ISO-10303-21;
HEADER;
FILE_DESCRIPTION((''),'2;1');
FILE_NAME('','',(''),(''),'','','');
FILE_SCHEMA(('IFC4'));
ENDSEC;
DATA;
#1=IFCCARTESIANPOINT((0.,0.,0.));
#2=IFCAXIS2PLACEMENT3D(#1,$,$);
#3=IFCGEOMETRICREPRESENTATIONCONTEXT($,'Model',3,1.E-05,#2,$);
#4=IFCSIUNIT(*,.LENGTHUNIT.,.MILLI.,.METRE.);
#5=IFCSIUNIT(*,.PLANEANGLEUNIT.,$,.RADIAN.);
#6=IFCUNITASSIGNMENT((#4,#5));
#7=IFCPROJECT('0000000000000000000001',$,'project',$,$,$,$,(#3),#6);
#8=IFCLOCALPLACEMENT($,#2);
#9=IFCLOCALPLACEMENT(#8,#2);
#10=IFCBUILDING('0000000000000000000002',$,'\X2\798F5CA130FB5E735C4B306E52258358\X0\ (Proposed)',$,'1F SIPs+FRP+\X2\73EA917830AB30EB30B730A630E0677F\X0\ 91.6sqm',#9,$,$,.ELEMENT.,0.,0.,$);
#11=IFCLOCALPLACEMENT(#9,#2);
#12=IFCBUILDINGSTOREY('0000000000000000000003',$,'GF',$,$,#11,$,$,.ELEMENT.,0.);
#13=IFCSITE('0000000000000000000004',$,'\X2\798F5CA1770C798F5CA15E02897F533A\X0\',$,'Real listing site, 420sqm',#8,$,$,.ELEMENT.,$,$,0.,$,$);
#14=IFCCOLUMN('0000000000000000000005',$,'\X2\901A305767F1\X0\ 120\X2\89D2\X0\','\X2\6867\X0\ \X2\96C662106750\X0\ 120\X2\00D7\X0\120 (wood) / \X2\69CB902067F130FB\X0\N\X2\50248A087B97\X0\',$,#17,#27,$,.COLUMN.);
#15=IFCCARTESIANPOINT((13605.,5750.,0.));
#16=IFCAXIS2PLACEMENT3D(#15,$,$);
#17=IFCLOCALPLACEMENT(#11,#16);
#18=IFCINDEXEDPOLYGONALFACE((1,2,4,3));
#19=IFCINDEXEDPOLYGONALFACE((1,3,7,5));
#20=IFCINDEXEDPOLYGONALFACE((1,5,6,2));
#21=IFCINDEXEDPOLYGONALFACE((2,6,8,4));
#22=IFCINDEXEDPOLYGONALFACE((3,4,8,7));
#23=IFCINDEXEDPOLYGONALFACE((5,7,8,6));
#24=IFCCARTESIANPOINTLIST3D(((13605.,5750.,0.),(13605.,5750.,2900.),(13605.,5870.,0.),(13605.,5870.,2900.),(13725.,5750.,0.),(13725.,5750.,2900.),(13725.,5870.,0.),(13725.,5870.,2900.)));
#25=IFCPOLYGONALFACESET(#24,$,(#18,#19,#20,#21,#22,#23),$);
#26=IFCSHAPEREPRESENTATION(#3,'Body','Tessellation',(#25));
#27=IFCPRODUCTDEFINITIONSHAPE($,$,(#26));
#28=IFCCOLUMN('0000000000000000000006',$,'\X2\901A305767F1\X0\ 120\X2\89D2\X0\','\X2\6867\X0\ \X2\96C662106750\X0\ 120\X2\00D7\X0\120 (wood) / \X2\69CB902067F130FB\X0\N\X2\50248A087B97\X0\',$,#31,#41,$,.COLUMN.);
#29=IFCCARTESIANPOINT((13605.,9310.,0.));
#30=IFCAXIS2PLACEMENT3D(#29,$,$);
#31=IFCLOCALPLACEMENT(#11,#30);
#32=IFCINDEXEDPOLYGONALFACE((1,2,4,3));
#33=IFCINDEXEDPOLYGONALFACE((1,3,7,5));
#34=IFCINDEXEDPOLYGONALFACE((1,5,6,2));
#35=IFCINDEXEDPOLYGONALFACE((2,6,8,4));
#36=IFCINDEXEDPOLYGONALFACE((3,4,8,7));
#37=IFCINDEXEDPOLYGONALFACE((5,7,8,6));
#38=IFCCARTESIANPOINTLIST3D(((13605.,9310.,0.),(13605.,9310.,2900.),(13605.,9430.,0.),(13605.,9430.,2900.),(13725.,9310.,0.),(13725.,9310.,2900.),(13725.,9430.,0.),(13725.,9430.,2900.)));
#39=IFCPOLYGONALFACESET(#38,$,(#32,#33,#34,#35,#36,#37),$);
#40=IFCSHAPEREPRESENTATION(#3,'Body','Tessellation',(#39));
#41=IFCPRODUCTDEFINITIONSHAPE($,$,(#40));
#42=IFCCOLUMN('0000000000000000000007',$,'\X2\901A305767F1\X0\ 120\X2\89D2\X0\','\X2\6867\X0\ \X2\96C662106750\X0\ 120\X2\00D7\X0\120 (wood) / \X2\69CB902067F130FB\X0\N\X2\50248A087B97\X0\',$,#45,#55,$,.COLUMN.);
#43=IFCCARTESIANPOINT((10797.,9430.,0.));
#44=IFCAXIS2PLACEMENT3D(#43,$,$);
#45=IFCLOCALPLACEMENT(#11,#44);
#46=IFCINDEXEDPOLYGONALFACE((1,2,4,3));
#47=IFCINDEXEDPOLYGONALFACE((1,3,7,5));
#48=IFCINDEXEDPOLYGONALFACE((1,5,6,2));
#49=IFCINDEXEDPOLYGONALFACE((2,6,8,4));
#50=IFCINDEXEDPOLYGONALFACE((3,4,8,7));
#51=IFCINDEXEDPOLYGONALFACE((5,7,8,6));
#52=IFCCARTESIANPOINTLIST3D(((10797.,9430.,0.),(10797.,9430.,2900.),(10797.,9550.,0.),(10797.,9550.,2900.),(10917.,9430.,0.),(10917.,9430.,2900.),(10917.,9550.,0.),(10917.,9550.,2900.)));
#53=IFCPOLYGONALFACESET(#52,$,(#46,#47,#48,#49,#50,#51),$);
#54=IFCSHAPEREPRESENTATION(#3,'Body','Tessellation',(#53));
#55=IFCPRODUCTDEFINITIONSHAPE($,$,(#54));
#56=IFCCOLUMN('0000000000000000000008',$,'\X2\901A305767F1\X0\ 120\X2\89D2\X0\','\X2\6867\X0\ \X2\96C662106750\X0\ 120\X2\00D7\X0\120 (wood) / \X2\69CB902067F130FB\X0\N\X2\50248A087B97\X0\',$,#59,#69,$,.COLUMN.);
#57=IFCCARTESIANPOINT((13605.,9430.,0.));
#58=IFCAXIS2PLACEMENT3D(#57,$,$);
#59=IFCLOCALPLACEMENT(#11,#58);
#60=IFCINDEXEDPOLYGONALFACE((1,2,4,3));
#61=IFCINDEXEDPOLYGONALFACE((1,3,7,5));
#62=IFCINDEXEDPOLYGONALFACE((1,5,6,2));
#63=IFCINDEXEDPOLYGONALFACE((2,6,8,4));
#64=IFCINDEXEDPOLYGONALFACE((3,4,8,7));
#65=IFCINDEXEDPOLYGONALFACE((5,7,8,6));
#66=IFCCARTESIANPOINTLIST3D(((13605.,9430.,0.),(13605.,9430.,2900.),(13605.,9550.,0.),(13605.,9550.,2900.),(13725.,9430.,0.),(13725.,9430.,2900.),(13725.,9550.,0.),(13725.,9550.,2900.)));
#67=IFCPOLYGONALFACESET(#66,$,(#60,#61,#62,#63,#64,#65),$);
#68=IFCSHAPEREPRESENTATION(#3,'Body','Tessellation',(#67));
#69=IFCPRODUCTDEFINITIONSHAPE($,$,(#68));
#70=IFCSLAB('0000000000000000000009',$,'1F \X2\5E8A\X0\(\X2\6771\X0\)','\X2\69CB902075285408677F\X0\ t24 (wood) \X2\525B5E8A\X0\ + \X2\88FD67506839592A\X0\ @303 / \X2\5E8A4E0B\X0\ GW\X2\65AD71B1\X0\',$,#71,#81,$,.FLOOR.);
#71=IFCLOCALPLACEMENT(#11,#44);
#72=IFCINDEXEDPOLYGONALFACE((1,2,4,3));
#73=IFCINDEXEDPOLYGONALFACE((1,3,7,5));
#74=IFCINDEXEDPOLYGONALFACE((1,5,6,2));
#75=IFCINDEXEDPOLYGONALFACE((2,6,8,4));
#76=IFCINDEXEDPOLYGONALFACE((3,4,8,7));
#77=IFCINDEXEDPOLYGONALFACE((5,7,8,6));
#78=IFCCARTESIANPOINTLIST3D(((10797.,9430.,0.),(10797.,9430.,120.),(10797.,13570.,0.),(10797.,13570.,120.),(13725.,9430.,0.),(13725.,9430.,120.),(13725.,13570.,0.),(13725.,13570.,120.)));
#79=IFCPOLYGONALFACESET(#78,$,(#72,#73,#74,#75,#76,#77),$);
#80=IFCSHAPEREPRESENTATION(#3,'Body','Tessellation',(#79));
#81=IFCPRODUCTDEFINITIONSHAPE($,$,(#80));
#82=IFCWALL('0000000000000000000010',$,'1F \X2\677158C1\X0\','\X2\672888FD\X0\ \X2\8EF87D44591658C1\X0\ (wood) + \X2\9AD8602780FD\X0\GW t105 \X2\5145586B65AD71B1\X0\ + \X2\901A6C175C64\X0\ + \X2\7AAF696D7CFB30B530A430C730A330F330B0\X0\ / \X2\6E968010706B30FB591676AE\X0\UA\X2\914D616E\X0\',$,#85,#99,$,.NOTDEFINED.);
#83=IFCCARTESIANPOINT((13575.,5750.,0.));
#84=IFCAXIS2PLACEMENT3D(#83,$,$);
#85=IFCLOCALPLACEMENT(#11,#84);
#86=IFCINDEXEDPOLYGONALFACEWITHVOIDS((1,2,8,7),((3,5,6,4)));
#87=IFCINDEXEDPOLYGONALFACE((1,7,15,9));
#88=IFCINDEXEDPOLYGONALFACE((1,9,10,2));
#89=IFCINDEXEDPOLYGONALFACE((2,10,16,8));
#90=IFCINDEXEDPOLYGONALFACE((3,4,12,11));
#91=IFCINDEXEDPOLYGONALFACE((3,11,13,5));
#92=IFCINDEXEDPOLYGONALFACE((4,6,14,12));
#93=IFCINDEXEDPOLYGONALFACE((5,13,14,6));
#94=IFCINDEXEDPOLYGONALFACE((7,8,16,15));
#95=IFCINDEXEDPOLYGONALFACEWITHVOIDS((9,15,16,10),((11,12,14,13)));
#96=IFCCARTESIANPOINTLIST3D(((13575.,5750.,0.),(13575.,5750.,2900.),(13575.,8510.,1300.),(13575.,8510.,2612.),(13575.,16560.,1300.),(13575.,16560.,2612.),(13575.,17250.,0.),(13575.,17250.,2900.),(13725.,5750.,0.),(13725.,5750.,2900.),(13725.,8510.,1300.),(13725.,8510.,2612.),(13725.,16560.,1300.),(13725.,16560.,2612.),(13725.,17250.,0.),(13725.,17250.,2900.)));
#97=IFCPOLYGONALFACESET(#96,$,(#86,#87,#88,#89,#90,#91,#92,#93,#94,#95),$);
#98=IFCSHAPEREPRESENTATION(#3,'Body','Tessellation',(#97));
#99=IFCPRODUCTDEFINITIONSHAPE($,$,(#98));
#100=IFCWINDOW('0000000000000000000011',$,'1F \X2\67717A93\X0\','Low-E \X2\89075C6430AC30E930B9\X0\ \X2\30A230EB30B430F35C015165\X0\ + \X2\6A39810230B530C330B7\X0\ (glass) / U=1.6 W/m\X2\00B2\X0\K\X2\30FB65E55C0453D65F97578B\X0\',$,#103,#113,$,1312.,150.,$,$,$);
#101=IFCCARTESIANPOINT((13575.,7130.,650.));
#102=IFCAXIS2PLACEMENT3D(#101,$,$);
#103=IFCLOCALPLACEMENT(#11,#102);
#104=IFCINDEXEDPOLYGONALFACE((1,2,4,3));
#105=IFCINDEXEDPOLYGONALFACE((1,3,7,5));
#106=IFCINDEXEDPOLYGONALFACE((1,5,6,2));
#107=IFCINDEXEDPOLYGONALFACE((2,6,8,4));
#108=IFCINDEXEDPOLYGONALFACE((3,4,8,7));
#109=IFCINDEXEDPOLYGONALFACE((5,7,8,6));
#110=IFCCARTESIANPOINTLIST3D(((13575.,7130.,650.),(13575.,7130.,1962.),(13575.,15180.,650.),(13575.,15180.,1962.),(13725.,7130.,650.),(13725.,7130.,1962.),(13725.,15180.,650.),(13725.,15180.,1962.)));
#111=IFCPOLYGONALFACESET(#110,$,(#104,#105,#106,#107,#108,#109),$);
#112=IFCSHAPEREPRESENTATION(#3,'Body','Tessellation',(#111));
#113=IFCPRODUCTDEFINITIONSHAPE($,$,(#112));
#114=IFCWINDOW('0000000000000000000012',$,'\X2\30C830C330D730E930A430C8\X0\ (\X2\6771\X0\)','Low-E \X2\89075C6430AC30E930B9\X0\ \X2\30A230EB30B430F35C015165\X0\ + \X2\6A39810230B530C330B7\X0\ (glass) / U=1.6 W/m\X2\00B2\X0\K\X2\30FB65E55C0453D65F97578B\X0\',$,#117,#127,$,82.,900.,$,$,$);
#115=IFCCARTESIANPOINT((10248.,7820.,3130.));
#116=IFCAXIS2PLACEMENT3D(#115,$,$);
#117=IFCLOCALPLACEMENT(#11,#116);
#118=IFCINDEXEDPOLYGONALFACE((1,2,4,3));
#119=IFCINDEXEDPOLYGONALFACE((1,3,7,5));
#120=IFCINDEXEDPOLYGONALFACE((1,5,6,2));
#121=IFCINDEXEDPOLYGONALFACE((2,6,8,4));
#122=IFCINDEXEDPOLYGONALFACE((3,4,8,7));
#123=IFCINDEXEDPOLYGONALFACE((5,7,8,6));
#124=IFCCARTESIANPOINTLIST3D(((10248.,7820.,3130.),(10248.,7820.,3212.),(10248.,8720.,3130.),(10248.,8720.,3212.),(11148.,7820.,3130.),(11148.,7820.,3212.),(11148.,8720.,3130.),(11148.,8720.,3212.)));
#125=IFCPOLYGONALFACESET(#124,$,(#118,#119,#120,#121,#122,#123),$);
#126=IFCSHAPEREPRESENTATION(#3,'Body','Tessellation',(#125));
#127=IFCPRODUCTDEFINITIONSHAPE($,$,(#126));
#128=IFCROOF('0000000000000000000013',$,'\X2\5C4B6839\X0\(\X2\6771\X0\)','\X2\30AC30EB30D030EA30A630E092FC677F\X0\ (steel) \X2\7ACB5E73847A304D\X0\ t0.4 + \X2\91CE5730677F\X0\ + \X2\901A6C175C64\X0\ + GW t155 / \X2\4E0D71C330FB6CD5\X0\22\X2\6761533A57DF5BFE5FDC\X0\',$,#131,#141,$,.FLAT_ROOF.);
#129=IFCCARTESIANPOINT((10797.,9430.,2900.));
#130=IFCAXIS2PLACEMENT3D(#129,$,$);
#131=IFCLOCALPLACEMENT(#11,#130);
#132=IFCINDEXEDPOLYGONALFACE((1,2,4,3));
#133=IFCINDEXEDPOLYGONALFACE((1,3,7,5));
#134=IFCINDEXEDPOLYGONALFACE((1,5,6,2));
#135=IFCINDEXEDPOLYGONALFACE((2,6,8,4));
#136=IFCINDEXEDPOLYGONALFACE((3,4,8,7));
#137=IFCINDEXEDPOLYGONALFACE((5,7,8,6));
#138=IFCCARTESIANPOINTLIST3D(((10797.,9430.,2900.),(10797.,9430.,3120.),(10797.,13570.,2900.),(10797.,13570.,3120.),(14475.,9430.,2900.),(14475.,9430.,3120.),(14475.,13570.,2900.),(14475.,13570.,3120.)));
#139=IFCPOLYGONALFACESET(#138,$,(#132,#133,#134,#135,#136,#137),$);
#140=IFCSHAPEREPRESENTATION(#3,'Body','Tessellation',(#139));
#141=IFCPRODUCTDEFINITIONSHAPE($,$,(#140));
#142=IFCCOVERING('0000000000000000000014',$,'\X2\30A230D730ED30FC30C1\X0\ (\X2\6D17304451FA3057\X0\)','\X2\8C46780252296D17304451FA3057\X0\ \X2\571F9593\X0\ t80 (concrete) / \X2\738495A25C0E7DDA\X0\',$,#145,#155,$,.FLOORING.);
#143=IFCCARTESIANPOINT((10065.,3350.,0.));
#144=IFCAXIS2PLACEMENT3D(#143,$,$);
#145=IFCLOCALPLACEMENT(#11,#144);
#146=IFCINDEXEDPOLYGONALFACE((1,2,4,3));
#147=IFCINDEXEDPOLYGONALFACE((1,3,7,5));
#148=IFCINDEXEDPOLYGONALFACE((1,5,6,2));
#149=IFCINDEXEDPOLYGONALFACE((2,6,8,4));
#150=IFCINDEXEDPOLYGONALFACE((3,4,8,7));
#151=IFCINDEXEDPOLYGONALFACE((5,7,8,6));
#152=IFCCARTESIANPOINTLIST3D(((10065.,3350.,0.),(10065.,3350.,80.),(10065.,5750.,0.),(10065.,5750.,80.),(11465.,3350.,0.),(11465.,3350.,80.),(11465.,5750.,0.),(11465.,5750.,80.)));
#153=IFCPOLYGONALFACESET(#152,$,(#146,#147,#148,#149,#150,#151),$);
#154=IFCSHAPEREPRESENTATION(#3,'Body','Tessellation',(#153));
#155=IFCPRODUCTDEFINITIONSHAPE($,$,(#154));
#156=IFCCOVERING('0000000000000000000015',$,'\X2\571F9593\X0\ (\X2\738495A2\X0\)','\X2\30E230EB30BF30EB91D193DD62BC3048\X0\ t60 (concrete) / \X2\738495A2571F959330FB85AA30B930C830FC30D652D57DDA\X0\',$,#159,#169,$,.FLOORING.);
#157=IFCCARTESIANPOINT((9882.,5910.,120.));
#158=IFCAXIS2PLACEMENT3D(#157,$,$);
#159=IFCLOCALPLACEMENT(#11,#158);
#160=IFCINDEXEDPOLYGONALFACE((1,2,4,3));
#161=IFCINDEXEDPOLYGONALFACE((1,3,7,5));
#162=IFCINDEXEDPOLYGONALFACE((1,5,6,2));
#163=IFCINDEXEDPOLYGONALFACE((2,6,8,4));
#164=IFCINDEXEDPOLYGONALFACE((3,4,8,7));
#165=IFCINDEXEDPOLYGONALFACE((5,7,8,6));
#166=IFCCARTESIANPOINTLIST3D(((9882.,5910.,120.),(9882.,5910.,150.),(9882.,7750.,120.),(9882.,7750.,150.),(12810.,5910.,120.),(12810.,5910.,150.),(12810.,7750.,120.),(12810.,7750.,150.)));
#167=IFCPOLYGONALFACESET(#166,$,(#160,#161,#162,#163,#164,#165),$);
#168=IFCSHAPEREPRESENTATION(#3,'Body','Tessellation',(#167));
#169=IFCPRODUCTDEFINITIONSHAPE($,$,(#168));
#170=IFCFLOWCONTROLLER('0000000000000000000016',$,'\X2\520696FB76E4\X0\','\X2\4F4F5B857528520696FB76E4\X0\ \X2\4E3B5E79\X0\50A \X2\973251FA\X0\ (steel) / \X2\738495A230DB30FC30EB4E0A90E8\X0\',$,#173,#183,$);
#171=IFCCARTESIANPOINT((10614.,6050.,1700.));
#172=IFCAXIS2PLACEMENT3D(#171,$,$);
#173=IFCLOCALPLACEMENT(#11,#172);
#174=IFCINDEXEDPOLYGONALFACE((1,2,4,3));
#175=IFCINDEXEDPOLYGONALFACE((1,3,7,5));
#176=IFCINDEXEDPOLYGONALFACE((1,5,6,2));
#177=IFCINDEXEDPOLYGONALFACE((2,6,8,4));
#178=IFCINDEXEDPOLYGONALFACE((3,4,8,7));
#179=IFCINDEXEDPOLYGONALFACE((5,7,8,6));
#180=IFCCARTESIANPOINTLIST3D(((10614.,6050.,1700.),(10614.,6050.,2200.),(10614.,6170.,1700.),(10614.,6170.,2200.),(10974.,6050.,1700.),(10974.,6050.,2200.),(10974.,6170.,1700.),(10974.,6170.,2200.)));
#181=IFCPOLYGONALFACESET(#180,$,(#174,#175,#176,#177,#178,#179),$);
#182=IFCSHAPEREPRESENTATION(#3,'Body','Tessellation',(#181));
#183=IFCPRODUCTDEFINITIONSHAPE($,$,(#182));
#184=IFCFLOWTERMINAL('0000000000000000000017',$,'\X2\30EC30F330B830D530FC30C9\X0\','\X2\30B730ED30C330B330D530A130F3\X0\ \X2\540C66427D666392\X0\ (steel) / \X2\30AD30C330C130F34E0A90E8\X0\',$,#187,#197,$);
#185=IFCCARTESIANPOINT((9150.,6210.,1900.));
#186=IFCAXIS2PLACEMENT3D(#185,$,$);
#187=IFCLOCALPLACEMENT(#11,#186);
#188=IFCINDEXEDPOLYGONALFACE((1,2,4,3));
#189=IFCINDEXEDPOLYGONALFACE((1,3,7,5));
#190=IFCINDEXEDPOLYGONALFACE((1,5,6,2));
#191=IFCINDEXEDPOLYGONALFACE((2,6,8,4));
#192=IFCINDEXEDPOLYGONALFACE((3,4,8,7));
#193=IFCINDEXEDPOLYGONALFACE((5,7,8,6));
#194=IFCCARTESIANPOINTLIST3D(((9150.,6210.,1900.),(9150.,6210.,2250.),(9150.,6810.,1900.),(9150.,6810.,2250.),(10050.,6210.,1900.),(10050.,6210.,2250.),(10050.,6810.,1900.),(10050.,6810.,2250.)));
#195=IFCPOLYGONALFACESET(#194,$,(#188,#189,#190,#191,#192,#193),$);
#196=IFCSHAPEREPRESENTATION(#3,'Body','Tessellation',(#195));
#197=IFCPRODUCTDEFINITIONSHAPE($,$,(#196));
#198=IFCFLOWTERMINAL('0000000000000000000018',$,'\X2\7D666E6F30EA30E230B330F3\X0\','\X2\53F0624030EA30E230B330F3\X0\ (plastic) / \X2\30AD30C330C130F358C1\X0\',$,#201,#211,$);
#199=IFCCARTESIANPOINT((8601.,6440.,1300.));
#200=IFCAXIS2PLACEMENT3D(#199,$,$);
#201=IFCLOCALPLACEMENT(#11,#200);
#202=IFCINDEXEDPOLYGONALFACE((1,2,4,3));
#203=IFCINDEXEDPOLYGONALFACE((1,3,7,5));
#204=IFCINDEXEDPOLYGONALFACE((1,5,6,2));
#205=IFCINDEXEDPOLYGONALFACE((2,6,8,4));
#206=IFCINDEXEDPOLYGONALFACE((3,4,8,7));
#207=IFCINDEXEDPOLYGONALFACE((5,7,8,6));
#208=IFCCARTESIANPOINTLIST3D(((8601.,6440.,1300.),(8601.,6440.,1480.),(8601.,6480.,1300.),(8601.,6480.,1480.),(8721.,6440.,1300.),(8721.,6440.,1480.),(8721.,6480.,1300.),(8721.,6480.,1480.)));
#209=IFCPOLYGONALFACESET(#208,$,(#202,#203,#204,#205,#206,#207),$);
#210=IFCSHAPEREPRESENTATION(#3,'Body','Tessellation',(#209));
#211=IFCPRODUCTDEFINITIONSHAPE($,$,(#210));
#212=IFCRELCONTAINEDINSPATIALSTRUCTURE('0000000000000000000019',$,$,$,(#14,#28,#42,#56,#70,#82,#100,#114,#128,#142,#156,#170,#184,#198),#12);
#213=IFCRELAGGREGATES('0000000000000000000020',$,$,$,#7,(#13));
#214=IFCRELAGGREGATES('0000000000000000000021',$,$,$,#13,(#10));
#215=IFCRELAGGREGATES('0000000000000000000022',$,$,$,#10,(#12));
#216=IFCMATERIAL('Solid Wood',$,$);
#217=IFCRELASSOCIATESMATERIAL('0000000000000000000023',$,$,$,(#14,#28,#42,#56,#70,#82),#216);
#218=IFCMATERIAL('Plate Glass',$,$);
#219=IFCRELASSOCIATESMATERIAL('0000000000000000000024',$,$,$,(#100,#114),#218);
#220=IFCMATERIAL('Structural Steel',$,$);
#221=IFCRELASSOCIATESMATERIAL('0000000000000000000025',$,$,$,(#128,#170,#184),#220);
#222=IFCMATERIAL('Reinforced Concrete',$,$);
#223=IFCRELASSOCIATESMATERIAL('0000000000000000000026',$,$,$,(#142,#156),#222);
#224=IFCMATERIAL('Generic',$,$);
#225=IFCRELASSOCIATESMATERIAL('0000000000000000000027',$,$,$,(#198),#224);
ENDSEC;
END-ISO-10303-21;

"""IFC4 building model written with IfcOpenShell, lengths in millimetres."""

from ifc_helpers import new_model, si_unit, frame, frame_2d, origin, place, context, project, spatial, rectangle, extrude, material, element, fill, save


model = new_model("IFC4")

# Units and contexts
model_context = context("Model", 3, precision=1e-05, world=origin())
ifc_project = project(units=[si_unit("LENGTHUNIT", "METRE", prefix="MILLI"), si_unit("PLANEANGLEUNIT", "RADIAN")], contexts=[model_context])

# Site, building, storey
site_placement = place(None, origin())
site = spatial("IfcSite", under=ifc_project, at=site_placement, Name="福岡県福岡市西区", ObjectType="Real listing site, 420sqm", CompositionType="ELEMENT", RefElevation=0.0)
building_placement = place(site_placement, origin())
building = spatial("IfcBuilding", under=site, at=building_placement, Name="福岡・平屋の別荘 (Proposed)", ObjectType="1F SIPs+FRP+珪酸カルシウム板 91.6sqm", CompositionType="ELEMENT", ElevationOfRefHeight=0.0, ElevationOfTerrain=0.0)
storey_placement = place(building_placement, origin())
storey = spatial("IfcBuildingStorey", under=building, at=storey_placement, Name="GF", CompositionType="ELEMENT", Elevation=0.0)

# Columns
ifc_material_1 = material(Name="Solid Wood")
column_1_placement = place(storey_placement, frame((13605.0, 5750.0, 0.0)))
element("IfcColumn", 1, at=column_1_placement, inside=storey, material=ifc_material_1, Name="通し柱 120角", Description="桧 集成材 120×120 (wood) / 構造柱・N値計算", PredefinedType="COLUMN", context=model_context, shape_type="SweptSolid", body=[
    extrude(rectangle(XDim=120.0, YDim=120.0, at=frame_2d((60.0, 60.0))), frame((13605.0, 5750.0, 0.0)), (0.0, 0.0, 1.0), 2900.0),
])
column_2_placement = place(storey_placement, frame((13605.0, 9310.0, 0.0)))
element("IfcColumn", 2, at=column_2_placement, inside=storey, material=ifc_material_1, Name="通し柱 120角", Description="桧 集成材 120×120 (wood) / 構造柱・N値計算", PredefinedType="COLUMN", context=model_context, shape_type="SweptSolid", body=[
    extrude(rectangle(XDim=120.0, YDim=120.0, at=frame_2d((60.0, 60.0))), frame((13605.0, 9310.0, 0.0)), (0.0, 0.0, 1.0), 2900.0),
])
column_3_placement = place(storey_placement, frame((10797.0, 9430.0, 0.0)))
element("IfcColumn", 3, at=column_3_placement, inside=storey, material=ifc_material_1, Name="通し柱 120角", Description="桧 集成材 120×120 (wood) / 構造柱・N値計算", PredefinedType="COLUMN", context=model_context, shape_type="SweptSolid", body=[
    extrude(rectangle(XDim=120.0, YDim=120.0, at=frame_2d((60.0, 60.0))), frame((10797.0, 9430.0, 0.0)), (0.0, 0.0, 1.0), 2900.0),
])
column_4_placement = place(storey_placement, frame((13605.0, 9430.0, 0.0)))
element("IfcColumn", 4, at=column_4_placement, inside=storey, material=ifc_material_1, Name="通し柱 120角", Description="桧 集成材 120×120 (wood) / 構造柱・N値計算", PredefinedType="COLUMN", context=model_context, shape_type="SweptSolid", body=[
    extrude(rectangle(XDim=120.0, YDim=120.0, at=frame_2d((60.0, 60.0))), frame((13605.0, 9430.0, 0.0)), (0.0, 0.0, 1.0), 2900.0),
])

# Slab
slab_placement = place(storey_placement, frame((10797.0, 9430.0, 0.0)))
element("IfcSlab", 5, at=slab_placement, inside=storey, material=ifc_material_1, Name="1F 床(東)", Description="構造用合板 t24 (wood) 剛床 + 製材根太 @303 / 床下 GW断熱", PredefinedType="FLOOR", context=model_context, shape_type="SweptSolid", body=[
    extrude(rectangle(XDim=2928.0, YDim=4140.0, at=frame_2d((1464.0, 2070.0))), frame((10797.0, 9430.0, 0.0)), (0.0, 0.0, 1.0), 120.0),
])

# Wall, opening, window
wall_1_placement = place(storey_placement, frame((13575.0, 5750.0, 0.0)))
wall_1 = element("IfcWall", 6, at=wall_1_placement, inside=storey, material=ifc_material_1, Name="1F 東壁", Description="木製 軸組外壁 (wood) + 高性能GW t105 充填断熱 + 通気層 + 窯業系サイディング / 準耐火・外皮UA配慮", PredefinedType="NOTDEFINED", context=model_context, shape_type="SweptSolid", body=[
    extrude(rectangle(XDim=150.0, YDim=11500.0, at=frame_2d((75.0, 5750.0))), frame((13575.0, 5750.0, 0.0)), (0.0, 0.0, 1.0), 2900.0),
])
opening_placement = place(storey_placement, frame((13575.0, 7130.0, 650.0)))
opening = element("IfcOpeningElement", 7, at=opening_placement, cuts=wall_1, PredefinedType="NOTDEFINED", context=model_context, shape_type="SweptSolid", body=[
    extrude(rectangle(XDim=150.0, YDim=8050.0, at=frame_2d((75.0, 4025.0))), frame((13575.0, 7130.0, 650.0)), (0.0, 0.0, 1.0), 1312.0),
])
ifc_material_2 = material(Name="Plate Glass")
window_1_placement = place(storey_placement, frame((13575.0, 7130.0, 650.0)))
window_1 = element("IfcWindow", 8, at=window_1_placement, inside=storey, material=ifc_material_2, Name="1F 東窓", Description="Low-E 複層ガラス アルゴン封入 + 樹脂サッシ (glass) / U=1.6 W/m²K・日射取得型", OverallHeight=1312.0, OverallWidth=150.0, context=model_context, shape_type="SweptSolid", body=[
    extrude(rectangle(XDim=150.0, YDim=8050.0, at=frame_2d((75.0, 4025.0))), frame((13575.0, 7130.0, 650.0)), (0.0, 0.0, 1.0), 1312.0),
])
fill(opening, window_1)

# Window
window_2_placement = place(storey_placement, frame((10248.0, 7820.0, 3130.0)))
element("IfcWindow", 9, at=window_2_placement, inside=storey, material=ifc_material_2, Name="トップライト (東)", Description="Low-E 複層ガラス アルゴン封入 + 樹脂サッシ (glass) / U=1.6 W/m²K・日射取得型", OverallHeight=82.0, OverallWidth=900.0, context=model_context, shape_type="SweptSolid", body=[
    extrude(rectangle(XDim=900.0, YDim=900.0, at=frame_2d((450.0, 450.0))), frame((10248.0, 7820.0, 3130.0)), (0.0, 0.0, 1.0), 82.0),
])

# Roof
ifc_material_3 = material(Name="Structural Steel")
roof_placement = place(storey_placement, frame((10797.0, 9430.0, 2900.0)))
element("IfcRoof", 10, at=roof_placement, inside=storey, material=ifc_material_3, Name="屋根(東)", Description="ガルバリウム鋼板 (steel) 立平葺き t0.4 + 野地板 + 通気層 + GW t155 / 不燃・法22条区域対応", PredefinedType="FLAT_ROOF", context=model_context, shape_type="SweptSolid", body=[
    extrude(rectangle(XDim=3678.0, YDim=4140.0, at=frame_2d((1839.0, 2070.0))), frame((10797.0, 9430.0, 2900.0)), (0.0, 0.0, 1.0), 220.0),
])

# Coverings
ifc_material_4 = material(Name="Reinforced Concrete")
covering_1_placement = place(storey_placement, frame((10065.0, 3350.0, 0.0)))
element("IfcCovering", 11, at=covering_1_placement, inside=storey, material=ifc_material_4, Name="アプローチ (洗い出し)", Description="豆砂利洗い出し 土間 t80 (concrete) / 玄関導線", PredefinedType="FLOORING", context=model_context, shape_type="SweptSolid", body=[
    extrude(rectangle(XDim=1400.0, YDim=2400.0, at=frame_2d((700.0, 1200.0))), frame((10065.0, 3350.0, 0.0)), (0.0, 0.0, 1.0), 80.0),
])
covering_2_placement = place(storey_placement, frame((9882.0, 5910.0, 120.0)))
element("IfcCovering", 12, at=covering_2_placement, inside=storey, material=ifc_material_4, Name="土間 (玄関)", Description="モルタル金鏝押え t60 (concrete) / 玄関土間・薪ストーブ動線", PredefinedType="FLOORING", context=model_context, shape_type="SweptSolid", body=[
    extrude(rectangle(XDim=2928.0, YDim=1840.0, at=frame_2d((1464.0, 920.0))), frame((9882.0, 5910.0, 120.0)), (0.0, 0.0, 1.0), 30.0),
])

# Flow controller
flow_controller_placement = place(storey_placement, frame((10614.0, 6050.0, 1700.0)))
element("IfcFlowController", 13, at=flow_controller_placement, inside=storey, material=ifc_material_3, Name="分電盤", Description="住宅用分電盤 主幹50A 露出 (steel) / 玄関ホール上部", context=model_context, shape_type="SweptSolid", body=[
    extrude(rectangle(XDim=360.0, YDim=120.0, at=frame_2d((180.0, 60.0))), frame((10614.0, 6050.0, 1700.0)), (0.0, 0.0, 1.0), 500.0),
])

# Flow terminals
flow_terminal_1_placement = place(storey_placement, frame((9150.0, 6210.0, 1900.0)))
element("IfcFlowTerminal", 14, at=flow_terminal_1_placement, inside=storey, material=ifc_material_3, Name="レンジフード", Description="シロッコファン 同時給排 (steel) / キッチン上部", context=model_context, shape_type="SweptSolid", body=[
    extrude(rectangle(XDim=900.0, YDim=600.0, at=frame_2d((450.0, 300.0))), frame((9150.0, 6210.0, 1900.0)), (0.0, 0.0, 1.0), 350.0),
])
ifc_material_5 = material(Name="Generic")
flow_terminal_2_placement = place(storey_placement, frame((8601.0, 6440.0, 1300.0)))
element("IfcFlowTerminal", 15, at=flow_terminal_2_placement, inside=storey, material=ifc_material_5, Name="給湯リモコン", Description="台所リモコン (plastic) / キッチン壁", context=model_context, shape_type="SweptSolid", body=[
    extrude(rectangle(XDim=120.0, YDim=40.0, at=frame_2d((60.0, 20.0))), frame((8601.0, 6440.0, 1300.0)), (0.0, 0.0, 1.0), 180.0),
])

save(model, "model.ifc")
